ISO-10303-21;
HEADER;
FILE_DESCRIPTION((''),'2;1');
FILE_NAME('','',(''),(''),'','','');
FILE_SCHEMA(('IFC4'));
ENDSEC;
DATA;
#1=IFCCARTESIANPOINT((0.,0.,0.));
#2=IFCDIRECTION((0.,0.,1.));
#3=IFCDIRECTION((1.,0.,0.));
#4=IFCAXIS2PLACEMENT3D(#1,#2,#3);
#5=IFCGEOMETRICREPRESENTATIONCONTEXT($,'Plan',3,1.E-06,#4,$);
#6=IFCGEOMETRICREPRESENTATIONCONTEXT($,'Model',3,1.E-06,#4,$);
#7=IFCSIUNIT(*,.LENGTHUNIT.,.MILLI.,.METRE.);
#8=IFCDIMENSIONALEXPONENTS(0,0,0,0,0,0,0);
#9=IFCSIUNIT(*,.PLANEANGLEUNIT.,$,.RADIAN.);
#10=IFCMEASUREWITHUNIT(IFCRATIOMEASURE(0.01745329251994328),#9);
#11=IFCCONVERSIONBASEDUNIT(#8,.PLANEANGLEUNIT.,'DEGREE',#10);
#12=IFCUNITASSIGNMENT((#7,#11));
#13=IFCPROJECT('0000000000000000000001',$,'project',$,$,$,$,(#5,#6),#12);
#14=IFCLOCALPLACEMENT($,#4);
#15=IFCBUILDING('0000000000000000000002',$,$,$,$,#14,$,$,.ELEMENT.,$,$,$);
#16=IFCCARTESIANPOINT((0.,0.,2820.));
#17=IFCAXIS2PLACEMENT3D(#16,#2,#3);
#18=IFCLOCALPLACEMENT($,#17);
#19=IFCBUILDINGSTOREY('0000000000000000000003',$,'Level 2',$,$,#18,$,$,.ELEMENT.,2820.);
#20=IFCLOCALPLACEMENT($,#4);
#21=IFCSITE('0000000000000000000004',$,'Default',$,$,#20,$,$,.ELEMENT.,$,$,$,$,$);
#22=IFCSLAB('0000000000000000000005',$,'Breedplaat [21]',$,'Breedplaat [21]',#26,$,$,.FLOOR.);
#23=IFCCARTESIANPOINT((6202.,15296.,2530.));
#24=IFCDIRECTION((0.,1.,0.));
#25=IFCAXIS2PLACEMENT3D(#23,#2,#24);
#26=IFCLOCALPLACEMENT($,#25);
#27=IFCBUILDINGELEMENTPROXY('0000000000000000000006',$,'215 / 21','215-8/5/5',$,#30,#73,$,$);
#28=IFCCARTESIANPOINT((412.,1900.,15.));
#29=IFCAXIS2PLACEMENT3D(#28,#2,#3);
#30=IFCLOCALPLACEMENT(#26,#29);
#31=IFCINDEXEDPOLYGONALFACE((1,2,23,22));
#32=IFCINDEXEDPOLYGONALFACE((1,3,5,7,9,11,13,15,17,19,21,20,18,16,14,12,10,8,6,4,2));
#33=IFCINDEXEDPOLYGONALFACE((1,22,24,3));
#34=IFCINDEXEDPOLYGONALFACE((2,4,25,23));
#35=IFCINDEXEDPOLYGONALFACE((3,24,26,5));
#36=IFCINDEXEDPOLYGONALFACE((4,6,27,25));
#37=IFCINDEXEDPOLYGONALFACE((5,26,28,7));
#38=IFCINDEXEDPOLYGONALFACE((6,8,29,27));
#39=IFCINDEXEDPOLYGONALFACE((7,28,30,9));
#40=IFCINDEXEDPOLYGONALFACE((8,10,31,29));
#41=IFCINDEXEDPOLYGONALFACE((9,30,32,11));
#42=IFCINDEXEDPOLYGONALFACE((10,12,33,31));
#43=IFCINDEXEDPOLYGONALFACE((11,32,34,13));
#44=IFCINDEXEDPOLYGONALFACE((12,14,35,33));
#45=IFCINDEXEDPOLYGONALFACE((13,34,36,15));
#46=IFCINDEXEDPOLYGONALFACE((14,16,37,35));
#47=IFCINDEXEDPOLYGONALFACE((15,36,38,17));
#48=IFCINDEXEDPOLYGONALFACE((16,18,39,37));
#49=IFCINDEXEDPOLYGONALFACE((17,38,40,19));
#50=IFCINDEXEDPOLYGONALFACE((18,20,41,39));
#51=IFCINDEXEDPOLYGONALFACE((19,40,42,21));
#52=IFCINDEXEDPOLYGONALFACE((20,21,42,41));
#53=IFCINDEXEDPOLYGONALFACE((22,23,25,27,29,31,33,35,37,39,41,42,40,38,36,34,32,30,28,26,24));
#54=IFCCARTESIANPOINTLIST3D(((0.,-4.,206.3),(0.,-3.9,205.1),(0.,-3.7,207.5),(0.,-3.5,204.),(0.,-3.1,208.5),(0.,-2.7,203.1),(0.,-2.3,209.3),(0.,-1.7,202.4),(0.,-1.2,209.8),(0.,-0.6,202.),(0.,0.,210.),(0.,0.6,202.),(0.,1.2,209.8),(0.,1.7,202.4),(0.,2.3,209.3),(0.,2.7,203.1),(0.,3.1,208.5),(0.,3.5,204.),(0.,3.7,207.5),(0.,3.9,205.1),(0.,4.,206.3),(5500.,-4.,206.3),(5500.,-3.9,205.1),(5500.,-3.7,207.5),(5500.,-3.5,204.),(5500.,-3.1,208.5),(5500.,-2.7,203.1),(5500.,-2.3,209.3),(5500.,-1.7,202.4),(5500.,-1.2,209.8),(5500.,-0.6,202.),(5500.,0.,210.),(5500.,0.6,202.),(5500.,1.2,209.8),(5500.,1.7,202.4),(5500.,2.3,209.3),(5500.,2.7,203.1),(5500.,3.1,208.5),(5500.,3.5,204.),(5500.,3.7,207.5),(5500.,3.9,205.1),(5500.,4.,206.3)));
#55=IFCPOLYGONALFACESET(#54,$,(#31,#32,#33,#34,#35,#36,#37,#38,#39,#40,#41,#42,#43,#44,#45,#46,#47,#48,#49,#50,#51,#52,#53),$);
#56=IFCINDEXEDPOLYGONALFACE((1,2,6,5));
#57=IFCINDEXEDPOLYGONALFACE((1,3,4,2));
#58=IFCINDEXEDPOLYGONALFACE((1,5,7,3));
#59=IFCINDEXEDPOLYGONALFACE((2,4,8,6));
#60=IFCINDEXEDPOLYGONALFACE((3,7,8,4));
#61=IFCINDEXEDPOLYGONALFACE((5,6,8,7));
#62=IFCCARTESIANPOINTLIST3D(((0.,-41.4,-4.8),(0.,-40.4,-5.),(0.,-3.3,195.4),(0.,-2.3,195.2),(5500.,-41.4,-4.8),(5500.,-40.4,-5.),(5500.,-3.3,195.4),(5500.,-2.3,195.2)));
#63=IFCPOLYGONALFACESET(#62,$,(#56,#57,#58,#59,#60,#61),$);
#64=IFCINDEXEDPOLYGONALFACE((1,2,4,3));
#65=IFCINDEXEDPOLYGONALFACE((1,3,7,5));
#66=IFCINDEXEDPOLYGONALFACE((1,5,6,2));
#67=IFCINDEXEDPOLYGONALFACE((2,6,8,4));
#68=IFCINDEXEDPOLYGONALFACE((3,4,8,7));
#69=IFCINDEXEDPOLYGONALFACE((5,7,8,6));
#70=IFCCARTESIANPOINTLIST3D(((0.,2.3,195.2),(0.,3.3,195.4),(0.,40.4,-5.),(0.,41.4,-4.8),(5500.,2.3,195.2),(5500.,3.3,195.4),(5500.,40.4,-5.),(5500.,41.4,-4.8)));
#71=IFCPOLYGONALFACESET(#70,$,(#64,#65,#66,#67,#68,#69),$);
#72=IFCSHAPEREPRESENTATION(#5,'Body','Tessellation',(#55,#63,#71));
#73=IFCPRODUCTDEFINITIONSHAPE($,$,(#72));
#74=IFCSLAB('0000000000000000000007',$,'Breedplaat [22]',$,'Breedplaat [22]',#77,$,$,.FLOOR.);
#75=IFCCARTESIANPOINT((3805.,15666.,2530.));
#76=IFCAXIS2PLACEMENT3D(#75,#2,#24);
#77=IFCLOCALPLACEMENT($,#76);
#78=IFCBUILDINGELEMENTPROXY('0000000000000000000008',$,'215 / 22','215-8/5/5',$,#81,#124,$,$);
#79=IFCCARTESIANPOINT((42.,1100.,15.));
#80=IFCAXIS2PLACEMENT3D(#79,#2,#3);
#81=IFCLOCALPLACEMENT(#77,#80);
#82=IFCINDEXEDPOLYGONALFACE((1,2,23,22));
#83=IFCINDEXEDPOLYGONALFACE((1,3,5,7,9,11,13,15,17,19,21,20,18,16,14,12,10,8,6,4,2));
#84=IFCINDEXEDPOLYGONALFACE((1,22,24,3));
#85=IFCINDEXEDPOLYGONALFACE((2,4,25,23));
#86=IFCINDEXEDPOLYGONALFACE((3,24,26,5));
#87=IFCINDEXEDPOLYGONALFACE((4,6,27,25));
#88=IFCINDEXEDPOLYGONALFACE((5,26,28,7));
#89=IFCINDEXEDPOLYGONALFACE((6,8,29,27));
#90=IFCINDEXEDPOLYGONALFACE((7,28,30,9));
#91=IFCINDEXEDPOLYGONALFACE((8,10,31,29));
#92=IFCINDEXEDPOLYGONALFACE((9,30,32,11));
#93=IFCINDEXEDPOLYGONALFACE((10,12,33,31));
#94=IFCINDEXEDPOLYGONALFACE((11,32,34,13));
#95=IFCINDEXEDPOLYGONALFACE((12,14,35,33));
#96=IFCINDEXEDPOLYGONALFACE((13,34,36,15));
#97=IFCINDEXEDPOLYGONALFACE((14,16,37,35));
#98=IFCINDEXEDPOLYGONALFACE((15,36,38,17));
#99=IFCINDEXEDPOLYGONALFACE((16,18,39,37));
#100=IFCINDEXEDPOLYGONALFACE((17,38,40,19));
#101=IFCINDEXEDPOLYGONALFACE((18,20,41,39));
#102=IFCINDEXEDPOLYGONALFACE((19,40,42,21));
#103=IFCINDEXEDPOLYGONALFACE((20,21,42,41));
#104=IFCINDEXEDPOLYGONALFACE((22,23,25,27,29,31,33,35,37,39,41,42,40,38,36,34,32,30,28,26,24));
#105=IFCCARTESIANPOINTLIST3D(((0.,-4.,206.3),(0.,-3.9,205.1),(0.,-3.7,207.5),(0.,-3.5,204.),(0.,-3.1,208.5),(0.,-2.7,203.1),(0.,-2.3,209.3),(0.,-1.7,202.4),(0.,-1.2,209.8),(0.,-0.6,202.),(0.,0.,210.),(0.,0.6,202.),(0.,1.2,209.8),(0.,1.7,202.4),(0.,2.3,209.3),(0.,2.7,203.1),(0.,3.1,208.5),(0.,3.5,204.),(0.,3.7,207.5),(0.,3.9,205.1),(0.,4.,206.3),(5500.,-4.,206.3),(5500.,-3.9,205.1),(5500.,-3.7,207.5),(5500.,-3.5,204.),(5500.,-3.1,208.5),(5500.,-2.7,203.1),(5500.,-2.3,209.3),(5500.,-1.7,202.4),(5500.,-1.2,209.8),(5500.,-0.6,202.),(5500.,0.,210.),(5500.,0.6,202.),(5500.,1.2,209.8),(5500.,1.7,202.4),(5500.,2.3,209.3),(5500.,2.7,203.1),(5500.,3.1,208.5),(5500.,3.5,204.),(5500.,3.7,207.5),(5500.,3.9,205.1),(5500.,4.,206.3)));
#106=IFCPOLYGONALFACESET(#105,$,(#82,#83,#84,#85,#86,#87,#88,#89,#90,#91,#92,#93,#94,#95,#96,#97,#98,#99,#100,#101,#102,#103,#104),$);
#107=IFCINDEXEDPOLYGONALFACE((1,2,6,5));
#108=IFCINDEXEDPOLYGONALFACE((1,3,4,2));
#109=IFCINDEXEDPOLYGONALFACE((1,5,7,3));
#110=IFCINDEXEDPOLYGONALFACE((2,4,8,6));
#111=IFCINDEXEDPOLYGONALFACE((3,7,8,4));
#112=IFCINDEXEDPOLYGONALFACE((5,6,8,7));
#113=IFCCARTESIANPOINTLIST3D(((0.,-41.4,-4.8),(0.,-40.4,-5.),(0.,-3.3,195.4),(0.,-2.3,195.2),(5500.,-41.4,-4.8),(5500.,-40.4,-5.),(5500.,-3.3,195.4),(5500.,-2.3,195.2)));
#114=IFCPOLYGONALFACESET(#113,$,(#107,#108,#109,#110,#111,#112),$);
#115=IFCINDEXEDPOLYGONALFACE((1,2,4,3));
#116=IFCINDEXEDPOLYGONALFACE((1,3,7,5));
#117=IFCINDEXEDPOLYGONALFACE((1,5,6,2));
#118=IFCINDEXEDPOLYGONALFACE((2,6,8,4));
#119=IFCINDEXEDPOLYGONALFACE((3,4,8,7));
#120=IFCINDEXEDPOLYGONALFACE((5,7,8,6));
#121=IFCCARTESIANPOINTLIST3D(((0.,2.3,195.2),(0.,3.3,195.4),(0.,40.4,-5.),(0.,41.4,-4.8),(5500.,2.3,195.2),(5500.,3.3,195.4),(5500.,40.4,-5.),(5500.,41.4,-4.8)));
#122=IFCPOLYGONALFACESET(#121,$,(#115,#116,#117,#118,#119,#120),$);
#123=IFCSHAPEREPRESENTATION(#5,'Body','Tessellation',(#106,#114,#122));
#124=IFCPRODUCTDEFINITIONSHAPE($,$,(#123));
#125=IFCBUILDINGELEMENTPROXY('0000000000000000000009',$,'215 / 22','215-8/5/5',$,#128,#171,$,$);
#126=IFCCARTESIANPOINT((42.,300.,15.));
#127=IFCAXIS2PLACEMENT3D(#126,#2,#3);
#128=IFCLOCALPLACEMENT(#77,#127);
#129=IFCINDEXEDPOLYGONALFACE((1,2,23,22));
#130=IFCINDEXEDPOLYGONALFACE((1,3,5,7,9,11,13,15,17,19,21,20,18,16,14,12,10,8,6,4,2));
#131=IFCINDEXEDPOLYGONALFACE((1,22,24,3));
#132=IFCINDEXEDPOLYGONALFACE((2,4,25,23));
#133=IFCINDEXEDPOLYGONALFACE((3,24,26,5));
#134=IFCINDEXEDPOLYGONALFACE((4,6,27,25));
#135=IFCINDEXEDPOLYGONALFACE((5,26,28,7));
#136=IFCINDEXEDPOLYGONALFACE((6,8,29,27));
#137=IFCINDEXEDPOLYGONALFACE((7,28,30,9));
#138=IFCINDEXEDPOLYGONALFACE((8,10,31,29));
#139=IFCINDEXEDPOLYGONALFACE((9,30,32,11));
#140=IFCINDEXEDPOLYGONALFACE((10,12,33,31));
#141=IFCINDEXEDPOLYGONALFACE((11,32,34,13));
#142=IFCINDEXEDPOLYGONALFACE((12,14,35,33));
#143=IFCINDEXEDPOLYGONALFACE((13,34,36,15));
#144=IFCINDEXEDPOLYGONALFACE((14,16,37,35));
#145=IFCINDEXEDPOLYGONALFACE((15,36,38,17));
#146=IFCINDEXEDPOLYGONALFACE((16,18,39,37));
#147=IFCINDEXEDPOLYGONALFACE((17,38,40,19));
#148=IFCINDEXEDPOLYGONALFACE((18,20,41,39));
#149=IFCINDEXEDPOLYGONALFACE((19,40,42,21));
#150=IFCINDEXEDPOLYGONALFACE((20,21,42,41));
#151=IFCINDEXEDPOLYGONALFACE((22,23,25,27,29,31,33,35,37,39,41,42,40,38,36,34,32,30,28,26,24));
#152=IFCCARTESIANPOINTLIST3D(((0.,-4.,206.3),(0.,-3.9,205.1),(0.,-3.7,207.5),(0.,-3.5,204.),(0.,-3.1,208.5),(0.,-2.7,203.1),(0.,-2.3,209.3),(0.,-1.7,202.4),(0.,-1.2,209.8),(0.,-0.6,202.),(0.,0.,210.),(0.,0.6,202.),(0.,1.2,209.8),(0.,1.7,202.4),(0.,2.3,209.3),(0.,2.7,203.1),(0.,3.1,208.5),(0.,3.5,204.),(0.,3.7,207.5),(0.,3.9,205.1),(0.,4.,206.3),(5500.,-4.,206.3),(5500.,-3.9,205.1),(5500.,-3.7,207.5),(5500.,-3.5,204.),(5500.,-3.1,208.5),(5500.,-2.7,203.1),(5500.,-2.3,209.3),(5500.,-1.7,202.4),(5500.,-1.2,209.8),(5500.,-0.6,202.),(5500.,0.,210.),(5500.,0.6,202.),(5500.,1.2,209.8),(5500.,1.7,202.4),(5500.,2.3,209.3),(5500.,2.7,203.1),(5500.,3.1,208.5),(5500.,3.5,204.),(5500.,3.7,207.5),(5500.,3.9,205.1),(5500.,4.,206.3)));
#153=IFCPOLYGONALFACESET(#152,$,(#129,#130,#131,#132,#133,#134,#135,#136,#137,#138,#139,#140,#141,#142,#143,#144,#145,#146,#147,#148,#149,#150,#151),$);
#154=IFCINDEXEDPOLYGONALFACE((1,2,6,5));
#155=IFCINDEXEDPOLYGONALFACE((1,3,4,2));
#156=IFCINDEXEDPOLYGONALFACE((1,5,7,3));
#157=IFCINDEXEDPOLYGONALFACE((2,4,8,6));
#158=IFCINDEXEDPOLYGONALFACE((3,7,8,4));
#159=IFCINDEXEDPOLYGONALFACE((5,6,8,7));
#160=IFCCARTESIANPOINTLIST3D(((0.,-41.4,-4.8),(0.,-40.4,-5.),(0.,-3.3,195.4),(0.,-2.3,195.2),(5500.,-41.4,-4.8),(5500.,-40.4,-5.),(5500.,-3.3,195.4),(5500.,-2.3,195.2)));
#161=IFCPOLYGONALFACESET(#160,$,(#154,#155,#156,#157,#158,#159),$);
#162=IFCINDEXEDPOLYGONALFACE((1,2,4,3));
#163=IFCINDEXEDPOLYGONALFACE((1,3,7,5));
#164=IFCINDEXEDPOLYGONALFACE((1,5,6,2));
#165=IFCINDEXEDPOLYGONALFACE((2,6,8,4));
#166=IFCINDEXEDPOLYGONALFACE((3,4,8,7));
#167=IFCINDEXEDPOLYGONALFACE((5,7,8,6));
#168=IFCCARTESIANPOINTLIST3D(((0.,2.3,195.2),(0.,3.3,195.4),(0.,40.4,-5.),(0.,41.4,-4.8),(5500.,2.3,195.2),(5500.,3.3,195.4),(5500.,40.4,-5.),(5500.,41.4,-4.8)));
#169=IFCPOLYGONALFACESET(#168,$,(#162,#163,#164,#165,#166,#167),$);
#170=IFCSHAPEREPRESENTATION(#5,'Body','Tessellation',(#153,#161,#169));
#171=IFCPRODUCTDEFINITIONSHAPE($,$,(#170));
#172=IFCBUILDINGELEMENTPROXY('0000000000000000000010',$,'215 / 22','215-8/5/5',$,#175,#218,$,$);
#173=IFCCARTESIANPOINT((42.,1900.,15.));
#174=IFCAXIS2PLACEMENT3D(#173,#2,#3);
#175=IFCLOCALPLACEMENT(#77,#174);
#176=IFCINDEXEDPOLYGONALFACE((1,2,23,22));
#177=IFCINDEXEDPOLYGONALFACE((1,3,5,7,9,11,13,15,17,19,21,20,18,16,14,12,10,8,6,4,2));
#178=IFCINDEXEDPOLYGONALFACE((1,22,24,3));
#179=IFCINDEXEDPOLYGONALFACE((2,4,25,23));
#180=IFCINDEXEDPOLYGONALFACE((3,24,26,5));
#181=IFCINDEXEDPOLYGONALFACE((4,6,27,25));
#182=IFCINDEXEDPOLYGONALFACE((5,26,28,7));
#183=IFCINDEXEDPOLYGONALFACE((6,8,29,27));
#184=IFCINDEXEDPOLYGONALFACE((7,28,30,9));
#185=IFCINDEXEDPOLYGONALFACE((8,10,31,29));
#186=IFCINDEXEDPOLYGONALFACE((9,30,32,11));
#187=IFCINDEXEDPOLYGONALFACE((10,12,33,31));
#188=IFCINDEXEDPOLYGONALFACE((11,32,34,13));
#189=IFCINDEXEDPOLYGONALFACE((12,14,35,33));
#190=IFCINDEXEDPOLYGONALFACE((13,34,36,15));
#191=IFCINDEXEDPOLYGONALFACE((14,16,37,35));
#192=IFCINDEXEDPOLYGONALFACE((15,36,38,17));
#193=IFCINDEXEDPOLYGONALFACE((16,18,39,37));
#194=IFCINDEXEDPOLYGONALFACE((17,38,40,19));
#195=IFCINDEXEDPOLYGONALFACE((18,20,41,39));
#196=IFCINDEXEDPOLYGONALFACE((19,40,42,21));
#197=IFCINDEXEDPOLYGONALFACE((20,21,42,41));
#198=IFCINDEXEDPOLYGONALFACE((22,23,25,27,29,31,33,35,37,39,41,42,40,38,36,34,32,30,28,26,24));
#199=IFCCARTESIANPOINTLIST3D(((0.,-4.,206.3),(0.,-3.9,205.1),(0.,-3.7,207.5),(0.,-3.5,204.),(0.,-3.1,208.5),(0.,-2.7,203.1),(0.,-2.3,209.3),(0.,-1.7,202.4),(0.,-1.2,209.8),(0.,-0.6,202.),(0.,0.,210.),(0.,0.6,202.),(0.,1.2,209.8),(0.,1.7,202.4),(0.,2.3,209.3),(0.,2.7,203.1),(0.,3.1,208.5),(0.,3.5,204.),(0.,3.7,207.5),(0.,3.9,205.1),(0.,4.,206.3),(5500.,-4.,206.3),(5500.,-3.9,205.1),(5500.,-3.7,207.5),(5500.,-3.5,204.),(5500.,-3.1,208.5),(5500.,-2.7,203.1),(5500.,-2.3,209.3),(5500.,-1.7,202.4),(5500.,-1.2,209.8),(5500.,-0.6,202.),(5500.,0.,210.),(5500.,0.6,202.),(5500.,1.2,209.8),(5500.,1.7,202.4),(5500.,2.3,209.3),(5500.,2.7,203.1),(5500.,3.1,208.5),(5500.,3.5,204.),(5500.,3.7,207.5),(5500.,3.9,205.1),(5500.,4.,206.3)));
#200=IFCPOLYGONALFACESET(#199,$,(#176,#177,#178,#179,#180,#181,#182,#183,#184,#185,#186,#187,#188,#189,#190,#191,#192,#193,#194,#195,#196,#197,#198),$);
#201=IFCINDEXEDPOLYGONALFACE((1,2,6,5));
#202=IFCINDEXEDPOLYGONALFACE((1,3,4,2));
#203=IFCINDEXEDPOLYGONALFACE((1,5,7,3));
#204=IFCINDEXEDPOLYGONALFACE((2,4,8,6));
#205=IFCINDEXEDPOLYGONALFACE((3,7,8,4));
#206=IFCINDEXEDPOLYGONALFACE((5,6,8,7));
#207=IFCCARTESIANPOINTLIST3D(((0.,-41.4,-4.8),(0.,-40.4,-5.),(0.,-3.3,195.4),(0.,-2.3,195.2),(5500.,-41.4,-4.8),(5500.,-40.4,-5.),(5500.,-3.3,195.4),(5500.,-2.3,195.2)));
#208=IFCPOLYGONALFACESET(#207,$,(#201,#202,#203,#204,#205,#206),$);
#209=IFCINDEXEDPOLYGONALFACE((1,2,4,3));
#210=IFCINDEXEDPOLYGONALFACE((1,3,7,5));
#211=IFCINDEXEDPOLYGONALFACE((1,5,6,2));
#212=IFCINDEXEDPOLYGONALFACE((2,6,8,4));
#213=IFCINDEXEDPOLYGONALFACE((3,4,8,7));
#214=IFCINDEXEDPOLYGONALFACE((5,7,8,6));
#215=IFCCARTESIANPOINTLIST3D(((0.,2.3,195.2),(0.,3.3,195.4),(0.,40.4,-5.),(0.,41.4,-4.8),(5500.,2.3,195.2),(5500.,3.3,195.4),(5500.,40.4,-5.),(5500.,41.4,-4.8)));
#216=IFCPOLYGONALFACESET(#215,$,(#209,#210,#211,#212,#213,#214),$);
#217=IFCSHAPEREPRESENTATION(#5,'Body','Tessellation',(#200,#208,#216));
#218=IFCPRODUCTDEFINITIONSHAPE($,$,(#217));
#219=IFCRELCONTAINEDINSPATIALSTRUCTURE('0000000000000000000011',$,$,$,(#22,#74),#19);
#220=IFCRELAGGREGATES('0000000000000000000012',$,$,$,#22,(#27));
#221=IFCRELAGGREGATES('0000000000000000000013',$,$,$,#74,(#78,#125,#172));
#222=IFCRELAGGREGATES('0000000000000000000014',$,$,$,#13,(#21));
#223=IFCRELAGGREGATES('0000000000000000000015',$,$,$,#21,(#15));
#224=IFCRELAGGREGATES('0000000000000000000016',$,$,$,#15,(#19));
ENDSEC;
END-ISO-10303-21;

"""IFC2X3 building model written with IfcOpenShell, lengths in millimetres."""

from ifc_helpers import new_model, entity, si_unit, converted_unit, frame, origin_with_axes, origin_2d_with_axis, place, context, project, spatial, rectangle, circle, extrude, element, aggregate, save


model = new_model("IFC2X3")

# Units and contexts
plan_context = context("Plan", 3, precision=1e-06, world=origin_with_axes())
model_context = context("Model", 3, precision=1e-06, world=origin_with_axes())
ifc_project = project(units=[si_unit("LENGTHUNIT", "METRE", prefix="MILLI"), converted_unit("PLANEANGLEUNIT", "DEGREE", entity("IfcRatioMeasure", 0.01745329251994328), si_unit("PLANEANGLEUNIT", "RADIAN"), dimensions=[0, 0, 0, 0, 0, 0, 0])], contexts=[plan_context, model_context])

# Site, building, storey
site_placement = place(None, origin_with_axes())
site = spatial("IfcSite", under=ifc_project, at=site_placement, Name="Default", CompositionType="ELEMENT")
building_placement = place(None, origin_with_axes())
building = spatial("IfcBuilding", under=site, at=building_placement, CompositionType="ELEMENT")
storey_placement = place(None, frame((0.0, 0.0, 2820.0), z_axis=(0.0, 0.0, 1.0), x_axis=(1.0, 0.0, 0.0)))
storey = spatial("IfcBuildingStorey", under=building, at=storey_placement, Name="Level 2", CompositionType="ELEMENT", Elevation=2820.0)

# Slabs, building element proxies
slab_1_placement = place(None, frame((6202.0, 15296.0, 2530.0), z_axis=(0.0, 0.0, 1.0), x_axis=(0.0, 1.0, 0.0)))
slab_1 = element("IfcSlab", 1, at=slab_1_placement, inside=storey, Name="Breedplaat [21]", ObjectType="Breedplaat [21]", PredefinedType="FLOOR")
proxy_1_placement = place(slab_1_placement, frame((412.0, 1900.0, 15.0), z_axis=(0.0, 0.0, 1.0), x_axis=(1.0, 0.0, 0.0)))
proxy_1 = element("IfcBuildingElementProxy", 2, at=proxy_1_placement, Name="215 / 21", Description="215-8/5/5", context=plan_context, shape_type="SweptSolid", body=[
    extrude(circle(Radius=4.0, at=origin_2d_with_axis()), frame((0.0, 0.0, 206.0), z_axis=(1.0, 0.0, 0.0), x_axis=(0.0, 0.0, 1.0)), (0.0, 0.0, 1.0), 5500.0),
    extrude(rectangle(XDim=203.8, YDim=1.0, at=origin_2d_with_axis()), frame((0.0, -21.9, 95.2), z_axis=(1.0, 0.0, 0.0), x_axis=(0.0, 0.187112, 0.982339)), (0.0, 0.0, 1.0), 5500.0),
    extrude(rectangle(XDim=203.8, YDim=1.0, at=origin_2d_with_axis()), frame((0.0, 21.9, 95.2), z_axis=(1.0, 0.0, 0.0), x_axis=(0.0, -0.187112, 0.982339)), (0.0, 0.0, 1.0), 5500.0),
])
aggregate(slab_1, [proxy_1])
slab_2_placement = place(None, frame((3805.0, 15666.0, 2530.0), z_axis=(0.0, 0.0, 1.0), x_axis=(0.0, 1.0, 0.0)))
slab_2 = element("IfcSlab", 3, at=slab_2_placement, inside=storey, Name="Breedplaat [22]", ObjectType="Breedplaat [22]", PredefinedType="FLOOR")
proxy_2_placement = place(slab_2_placement, frame((42.0, 1100.0, 15.0), z_axis=(0.0, 0.0, 1.0), x_axis=(1.0, 0.0, 0.0)))
proxy_2 = element("IfcBuildingElementProxy", 4, at=proxy_2_placement, Name="215 / 22", Description="215-8/5/5", context=plan_context, shape_type="SweptSolid", body=[
    extrude(circle(Radius=4.0, at=origin_2d_with_axis()), frame((0.0, 0.0, 206.0), z_axis=(1.0, 0.0, 0.0), x_axis=(0.0, 0.0, 1.0)), (0.0, 0.0, 1.0), 5500.0),
    extrude(rectangle(XDim=203.8, YDim=1.0, at=origin_2d_with_axis()), frame((0.0, -21.9, 95.2), z_axis=(1.0, 0.0, 0.0), x_axis=(0.0, 0.187112, 0.982339)), (0.0, 0.0, 1.0), 5500.0),
    extrude(rectangle(XDim=203.8, YDim=1.0, at=origin_2d_with_axis()), frame((0.0, 21.9, 95.2), z_axis=(1.0, 0.0, 0.0), x_axis=(0.0, -0.187112, 0.982339)), (0.0, 0.0, 1.0), 5500.0),
])
proxy_3_placement = place(slab_2_placement, frame((42.0, 300.0, 15.0), z_axis=(0.0, 0.0, 1.0), x_axis=(1.0, 0.0, 0.0)))
proxy_3 = element("IfcBuildingElementProxy", 5, at=proxy_3_placement, Name="215 / 22", Description="215-8/5/5", context=plan_context, shape_type="SweptSolid", body=[
    extrude(circle(Radius=4.0, at=origin_2d_with_axis()), frame((0.0, 0.0, 206.0), z_axis=(1.0, 0.0, 0.0), x_axis=(0.0, 0.0, 1.0)), (0.0, 0.0, 1.0), 5500.0),
    extrude(rectangle(XDim=203.8, YDim=1.0, at=origin_2d_with_axis()), frame((0.0, -21.9, 95.2), z_axis=(1.0, 0.0, 0.0), x_axis=(0.0, 0.187112, 0.982339)), (0.0, 0.0, 1.0), 5500.0),
    extrude(rectangle(XDim=203.8, YDim=1.0, at=origin_2d_with_axis()), frame((0.0, 21.9, 95.2), z_axis=(1.0, 0.0, 0.0), x_axis=(0.0, -0.187112, 0.982339)), (0.0, 0.0, 1.0), 5500.0),
])
proxy_4_placement = place(slab_2_placement, frame((42.0, 1900.0, 15.0), z_axis=(0.0, 0.0, 1.0), x_axis=(1.0, 0.0, 0.0)))
proxy_4 = element("IfcBuildingElementProxy", 6, at=proxy_4_placement, Name="215 / 22", Description="215-8/5/5", context=plan_context, shape_type="SweptSolid", body=[
    extrude(circle(Radius=4.0, at=origin_2d_with_axis()), frame((0.0, 0.0, 206.0), z_axis=(1.0, 0.0, 0.0), x_axis=(0.0, 0.0, 1.0)), (0.0, 0.0, 1.0), 5500.0),
    extrude(rectangle(XDim=203.8, YDim=1.0, at=origin_2d_with_axis()), frame((0.0, -21.9, 95.2), z_axis=(1.0, 0.0, 0.0), x_axis=(0.0, 0.187112, 0.982339)), (0.0, 0.0, 1.0), 5500.0),
    extrude(rectangle(XDim=203.8, YDim=1.0, at=origin_2d_with_axis()), frame((0.0, 21.9, 95.2), z_axis=(1.0, 0.0, 0.0), x_axis=(0.0, -0.187112, 0.982339)), (0.0, 0.0, 1.0), 5500.0),
])
aggregate(slab_2, [proxy_2, proxy_3, proxy_4])

save(model, "model.ifc")
